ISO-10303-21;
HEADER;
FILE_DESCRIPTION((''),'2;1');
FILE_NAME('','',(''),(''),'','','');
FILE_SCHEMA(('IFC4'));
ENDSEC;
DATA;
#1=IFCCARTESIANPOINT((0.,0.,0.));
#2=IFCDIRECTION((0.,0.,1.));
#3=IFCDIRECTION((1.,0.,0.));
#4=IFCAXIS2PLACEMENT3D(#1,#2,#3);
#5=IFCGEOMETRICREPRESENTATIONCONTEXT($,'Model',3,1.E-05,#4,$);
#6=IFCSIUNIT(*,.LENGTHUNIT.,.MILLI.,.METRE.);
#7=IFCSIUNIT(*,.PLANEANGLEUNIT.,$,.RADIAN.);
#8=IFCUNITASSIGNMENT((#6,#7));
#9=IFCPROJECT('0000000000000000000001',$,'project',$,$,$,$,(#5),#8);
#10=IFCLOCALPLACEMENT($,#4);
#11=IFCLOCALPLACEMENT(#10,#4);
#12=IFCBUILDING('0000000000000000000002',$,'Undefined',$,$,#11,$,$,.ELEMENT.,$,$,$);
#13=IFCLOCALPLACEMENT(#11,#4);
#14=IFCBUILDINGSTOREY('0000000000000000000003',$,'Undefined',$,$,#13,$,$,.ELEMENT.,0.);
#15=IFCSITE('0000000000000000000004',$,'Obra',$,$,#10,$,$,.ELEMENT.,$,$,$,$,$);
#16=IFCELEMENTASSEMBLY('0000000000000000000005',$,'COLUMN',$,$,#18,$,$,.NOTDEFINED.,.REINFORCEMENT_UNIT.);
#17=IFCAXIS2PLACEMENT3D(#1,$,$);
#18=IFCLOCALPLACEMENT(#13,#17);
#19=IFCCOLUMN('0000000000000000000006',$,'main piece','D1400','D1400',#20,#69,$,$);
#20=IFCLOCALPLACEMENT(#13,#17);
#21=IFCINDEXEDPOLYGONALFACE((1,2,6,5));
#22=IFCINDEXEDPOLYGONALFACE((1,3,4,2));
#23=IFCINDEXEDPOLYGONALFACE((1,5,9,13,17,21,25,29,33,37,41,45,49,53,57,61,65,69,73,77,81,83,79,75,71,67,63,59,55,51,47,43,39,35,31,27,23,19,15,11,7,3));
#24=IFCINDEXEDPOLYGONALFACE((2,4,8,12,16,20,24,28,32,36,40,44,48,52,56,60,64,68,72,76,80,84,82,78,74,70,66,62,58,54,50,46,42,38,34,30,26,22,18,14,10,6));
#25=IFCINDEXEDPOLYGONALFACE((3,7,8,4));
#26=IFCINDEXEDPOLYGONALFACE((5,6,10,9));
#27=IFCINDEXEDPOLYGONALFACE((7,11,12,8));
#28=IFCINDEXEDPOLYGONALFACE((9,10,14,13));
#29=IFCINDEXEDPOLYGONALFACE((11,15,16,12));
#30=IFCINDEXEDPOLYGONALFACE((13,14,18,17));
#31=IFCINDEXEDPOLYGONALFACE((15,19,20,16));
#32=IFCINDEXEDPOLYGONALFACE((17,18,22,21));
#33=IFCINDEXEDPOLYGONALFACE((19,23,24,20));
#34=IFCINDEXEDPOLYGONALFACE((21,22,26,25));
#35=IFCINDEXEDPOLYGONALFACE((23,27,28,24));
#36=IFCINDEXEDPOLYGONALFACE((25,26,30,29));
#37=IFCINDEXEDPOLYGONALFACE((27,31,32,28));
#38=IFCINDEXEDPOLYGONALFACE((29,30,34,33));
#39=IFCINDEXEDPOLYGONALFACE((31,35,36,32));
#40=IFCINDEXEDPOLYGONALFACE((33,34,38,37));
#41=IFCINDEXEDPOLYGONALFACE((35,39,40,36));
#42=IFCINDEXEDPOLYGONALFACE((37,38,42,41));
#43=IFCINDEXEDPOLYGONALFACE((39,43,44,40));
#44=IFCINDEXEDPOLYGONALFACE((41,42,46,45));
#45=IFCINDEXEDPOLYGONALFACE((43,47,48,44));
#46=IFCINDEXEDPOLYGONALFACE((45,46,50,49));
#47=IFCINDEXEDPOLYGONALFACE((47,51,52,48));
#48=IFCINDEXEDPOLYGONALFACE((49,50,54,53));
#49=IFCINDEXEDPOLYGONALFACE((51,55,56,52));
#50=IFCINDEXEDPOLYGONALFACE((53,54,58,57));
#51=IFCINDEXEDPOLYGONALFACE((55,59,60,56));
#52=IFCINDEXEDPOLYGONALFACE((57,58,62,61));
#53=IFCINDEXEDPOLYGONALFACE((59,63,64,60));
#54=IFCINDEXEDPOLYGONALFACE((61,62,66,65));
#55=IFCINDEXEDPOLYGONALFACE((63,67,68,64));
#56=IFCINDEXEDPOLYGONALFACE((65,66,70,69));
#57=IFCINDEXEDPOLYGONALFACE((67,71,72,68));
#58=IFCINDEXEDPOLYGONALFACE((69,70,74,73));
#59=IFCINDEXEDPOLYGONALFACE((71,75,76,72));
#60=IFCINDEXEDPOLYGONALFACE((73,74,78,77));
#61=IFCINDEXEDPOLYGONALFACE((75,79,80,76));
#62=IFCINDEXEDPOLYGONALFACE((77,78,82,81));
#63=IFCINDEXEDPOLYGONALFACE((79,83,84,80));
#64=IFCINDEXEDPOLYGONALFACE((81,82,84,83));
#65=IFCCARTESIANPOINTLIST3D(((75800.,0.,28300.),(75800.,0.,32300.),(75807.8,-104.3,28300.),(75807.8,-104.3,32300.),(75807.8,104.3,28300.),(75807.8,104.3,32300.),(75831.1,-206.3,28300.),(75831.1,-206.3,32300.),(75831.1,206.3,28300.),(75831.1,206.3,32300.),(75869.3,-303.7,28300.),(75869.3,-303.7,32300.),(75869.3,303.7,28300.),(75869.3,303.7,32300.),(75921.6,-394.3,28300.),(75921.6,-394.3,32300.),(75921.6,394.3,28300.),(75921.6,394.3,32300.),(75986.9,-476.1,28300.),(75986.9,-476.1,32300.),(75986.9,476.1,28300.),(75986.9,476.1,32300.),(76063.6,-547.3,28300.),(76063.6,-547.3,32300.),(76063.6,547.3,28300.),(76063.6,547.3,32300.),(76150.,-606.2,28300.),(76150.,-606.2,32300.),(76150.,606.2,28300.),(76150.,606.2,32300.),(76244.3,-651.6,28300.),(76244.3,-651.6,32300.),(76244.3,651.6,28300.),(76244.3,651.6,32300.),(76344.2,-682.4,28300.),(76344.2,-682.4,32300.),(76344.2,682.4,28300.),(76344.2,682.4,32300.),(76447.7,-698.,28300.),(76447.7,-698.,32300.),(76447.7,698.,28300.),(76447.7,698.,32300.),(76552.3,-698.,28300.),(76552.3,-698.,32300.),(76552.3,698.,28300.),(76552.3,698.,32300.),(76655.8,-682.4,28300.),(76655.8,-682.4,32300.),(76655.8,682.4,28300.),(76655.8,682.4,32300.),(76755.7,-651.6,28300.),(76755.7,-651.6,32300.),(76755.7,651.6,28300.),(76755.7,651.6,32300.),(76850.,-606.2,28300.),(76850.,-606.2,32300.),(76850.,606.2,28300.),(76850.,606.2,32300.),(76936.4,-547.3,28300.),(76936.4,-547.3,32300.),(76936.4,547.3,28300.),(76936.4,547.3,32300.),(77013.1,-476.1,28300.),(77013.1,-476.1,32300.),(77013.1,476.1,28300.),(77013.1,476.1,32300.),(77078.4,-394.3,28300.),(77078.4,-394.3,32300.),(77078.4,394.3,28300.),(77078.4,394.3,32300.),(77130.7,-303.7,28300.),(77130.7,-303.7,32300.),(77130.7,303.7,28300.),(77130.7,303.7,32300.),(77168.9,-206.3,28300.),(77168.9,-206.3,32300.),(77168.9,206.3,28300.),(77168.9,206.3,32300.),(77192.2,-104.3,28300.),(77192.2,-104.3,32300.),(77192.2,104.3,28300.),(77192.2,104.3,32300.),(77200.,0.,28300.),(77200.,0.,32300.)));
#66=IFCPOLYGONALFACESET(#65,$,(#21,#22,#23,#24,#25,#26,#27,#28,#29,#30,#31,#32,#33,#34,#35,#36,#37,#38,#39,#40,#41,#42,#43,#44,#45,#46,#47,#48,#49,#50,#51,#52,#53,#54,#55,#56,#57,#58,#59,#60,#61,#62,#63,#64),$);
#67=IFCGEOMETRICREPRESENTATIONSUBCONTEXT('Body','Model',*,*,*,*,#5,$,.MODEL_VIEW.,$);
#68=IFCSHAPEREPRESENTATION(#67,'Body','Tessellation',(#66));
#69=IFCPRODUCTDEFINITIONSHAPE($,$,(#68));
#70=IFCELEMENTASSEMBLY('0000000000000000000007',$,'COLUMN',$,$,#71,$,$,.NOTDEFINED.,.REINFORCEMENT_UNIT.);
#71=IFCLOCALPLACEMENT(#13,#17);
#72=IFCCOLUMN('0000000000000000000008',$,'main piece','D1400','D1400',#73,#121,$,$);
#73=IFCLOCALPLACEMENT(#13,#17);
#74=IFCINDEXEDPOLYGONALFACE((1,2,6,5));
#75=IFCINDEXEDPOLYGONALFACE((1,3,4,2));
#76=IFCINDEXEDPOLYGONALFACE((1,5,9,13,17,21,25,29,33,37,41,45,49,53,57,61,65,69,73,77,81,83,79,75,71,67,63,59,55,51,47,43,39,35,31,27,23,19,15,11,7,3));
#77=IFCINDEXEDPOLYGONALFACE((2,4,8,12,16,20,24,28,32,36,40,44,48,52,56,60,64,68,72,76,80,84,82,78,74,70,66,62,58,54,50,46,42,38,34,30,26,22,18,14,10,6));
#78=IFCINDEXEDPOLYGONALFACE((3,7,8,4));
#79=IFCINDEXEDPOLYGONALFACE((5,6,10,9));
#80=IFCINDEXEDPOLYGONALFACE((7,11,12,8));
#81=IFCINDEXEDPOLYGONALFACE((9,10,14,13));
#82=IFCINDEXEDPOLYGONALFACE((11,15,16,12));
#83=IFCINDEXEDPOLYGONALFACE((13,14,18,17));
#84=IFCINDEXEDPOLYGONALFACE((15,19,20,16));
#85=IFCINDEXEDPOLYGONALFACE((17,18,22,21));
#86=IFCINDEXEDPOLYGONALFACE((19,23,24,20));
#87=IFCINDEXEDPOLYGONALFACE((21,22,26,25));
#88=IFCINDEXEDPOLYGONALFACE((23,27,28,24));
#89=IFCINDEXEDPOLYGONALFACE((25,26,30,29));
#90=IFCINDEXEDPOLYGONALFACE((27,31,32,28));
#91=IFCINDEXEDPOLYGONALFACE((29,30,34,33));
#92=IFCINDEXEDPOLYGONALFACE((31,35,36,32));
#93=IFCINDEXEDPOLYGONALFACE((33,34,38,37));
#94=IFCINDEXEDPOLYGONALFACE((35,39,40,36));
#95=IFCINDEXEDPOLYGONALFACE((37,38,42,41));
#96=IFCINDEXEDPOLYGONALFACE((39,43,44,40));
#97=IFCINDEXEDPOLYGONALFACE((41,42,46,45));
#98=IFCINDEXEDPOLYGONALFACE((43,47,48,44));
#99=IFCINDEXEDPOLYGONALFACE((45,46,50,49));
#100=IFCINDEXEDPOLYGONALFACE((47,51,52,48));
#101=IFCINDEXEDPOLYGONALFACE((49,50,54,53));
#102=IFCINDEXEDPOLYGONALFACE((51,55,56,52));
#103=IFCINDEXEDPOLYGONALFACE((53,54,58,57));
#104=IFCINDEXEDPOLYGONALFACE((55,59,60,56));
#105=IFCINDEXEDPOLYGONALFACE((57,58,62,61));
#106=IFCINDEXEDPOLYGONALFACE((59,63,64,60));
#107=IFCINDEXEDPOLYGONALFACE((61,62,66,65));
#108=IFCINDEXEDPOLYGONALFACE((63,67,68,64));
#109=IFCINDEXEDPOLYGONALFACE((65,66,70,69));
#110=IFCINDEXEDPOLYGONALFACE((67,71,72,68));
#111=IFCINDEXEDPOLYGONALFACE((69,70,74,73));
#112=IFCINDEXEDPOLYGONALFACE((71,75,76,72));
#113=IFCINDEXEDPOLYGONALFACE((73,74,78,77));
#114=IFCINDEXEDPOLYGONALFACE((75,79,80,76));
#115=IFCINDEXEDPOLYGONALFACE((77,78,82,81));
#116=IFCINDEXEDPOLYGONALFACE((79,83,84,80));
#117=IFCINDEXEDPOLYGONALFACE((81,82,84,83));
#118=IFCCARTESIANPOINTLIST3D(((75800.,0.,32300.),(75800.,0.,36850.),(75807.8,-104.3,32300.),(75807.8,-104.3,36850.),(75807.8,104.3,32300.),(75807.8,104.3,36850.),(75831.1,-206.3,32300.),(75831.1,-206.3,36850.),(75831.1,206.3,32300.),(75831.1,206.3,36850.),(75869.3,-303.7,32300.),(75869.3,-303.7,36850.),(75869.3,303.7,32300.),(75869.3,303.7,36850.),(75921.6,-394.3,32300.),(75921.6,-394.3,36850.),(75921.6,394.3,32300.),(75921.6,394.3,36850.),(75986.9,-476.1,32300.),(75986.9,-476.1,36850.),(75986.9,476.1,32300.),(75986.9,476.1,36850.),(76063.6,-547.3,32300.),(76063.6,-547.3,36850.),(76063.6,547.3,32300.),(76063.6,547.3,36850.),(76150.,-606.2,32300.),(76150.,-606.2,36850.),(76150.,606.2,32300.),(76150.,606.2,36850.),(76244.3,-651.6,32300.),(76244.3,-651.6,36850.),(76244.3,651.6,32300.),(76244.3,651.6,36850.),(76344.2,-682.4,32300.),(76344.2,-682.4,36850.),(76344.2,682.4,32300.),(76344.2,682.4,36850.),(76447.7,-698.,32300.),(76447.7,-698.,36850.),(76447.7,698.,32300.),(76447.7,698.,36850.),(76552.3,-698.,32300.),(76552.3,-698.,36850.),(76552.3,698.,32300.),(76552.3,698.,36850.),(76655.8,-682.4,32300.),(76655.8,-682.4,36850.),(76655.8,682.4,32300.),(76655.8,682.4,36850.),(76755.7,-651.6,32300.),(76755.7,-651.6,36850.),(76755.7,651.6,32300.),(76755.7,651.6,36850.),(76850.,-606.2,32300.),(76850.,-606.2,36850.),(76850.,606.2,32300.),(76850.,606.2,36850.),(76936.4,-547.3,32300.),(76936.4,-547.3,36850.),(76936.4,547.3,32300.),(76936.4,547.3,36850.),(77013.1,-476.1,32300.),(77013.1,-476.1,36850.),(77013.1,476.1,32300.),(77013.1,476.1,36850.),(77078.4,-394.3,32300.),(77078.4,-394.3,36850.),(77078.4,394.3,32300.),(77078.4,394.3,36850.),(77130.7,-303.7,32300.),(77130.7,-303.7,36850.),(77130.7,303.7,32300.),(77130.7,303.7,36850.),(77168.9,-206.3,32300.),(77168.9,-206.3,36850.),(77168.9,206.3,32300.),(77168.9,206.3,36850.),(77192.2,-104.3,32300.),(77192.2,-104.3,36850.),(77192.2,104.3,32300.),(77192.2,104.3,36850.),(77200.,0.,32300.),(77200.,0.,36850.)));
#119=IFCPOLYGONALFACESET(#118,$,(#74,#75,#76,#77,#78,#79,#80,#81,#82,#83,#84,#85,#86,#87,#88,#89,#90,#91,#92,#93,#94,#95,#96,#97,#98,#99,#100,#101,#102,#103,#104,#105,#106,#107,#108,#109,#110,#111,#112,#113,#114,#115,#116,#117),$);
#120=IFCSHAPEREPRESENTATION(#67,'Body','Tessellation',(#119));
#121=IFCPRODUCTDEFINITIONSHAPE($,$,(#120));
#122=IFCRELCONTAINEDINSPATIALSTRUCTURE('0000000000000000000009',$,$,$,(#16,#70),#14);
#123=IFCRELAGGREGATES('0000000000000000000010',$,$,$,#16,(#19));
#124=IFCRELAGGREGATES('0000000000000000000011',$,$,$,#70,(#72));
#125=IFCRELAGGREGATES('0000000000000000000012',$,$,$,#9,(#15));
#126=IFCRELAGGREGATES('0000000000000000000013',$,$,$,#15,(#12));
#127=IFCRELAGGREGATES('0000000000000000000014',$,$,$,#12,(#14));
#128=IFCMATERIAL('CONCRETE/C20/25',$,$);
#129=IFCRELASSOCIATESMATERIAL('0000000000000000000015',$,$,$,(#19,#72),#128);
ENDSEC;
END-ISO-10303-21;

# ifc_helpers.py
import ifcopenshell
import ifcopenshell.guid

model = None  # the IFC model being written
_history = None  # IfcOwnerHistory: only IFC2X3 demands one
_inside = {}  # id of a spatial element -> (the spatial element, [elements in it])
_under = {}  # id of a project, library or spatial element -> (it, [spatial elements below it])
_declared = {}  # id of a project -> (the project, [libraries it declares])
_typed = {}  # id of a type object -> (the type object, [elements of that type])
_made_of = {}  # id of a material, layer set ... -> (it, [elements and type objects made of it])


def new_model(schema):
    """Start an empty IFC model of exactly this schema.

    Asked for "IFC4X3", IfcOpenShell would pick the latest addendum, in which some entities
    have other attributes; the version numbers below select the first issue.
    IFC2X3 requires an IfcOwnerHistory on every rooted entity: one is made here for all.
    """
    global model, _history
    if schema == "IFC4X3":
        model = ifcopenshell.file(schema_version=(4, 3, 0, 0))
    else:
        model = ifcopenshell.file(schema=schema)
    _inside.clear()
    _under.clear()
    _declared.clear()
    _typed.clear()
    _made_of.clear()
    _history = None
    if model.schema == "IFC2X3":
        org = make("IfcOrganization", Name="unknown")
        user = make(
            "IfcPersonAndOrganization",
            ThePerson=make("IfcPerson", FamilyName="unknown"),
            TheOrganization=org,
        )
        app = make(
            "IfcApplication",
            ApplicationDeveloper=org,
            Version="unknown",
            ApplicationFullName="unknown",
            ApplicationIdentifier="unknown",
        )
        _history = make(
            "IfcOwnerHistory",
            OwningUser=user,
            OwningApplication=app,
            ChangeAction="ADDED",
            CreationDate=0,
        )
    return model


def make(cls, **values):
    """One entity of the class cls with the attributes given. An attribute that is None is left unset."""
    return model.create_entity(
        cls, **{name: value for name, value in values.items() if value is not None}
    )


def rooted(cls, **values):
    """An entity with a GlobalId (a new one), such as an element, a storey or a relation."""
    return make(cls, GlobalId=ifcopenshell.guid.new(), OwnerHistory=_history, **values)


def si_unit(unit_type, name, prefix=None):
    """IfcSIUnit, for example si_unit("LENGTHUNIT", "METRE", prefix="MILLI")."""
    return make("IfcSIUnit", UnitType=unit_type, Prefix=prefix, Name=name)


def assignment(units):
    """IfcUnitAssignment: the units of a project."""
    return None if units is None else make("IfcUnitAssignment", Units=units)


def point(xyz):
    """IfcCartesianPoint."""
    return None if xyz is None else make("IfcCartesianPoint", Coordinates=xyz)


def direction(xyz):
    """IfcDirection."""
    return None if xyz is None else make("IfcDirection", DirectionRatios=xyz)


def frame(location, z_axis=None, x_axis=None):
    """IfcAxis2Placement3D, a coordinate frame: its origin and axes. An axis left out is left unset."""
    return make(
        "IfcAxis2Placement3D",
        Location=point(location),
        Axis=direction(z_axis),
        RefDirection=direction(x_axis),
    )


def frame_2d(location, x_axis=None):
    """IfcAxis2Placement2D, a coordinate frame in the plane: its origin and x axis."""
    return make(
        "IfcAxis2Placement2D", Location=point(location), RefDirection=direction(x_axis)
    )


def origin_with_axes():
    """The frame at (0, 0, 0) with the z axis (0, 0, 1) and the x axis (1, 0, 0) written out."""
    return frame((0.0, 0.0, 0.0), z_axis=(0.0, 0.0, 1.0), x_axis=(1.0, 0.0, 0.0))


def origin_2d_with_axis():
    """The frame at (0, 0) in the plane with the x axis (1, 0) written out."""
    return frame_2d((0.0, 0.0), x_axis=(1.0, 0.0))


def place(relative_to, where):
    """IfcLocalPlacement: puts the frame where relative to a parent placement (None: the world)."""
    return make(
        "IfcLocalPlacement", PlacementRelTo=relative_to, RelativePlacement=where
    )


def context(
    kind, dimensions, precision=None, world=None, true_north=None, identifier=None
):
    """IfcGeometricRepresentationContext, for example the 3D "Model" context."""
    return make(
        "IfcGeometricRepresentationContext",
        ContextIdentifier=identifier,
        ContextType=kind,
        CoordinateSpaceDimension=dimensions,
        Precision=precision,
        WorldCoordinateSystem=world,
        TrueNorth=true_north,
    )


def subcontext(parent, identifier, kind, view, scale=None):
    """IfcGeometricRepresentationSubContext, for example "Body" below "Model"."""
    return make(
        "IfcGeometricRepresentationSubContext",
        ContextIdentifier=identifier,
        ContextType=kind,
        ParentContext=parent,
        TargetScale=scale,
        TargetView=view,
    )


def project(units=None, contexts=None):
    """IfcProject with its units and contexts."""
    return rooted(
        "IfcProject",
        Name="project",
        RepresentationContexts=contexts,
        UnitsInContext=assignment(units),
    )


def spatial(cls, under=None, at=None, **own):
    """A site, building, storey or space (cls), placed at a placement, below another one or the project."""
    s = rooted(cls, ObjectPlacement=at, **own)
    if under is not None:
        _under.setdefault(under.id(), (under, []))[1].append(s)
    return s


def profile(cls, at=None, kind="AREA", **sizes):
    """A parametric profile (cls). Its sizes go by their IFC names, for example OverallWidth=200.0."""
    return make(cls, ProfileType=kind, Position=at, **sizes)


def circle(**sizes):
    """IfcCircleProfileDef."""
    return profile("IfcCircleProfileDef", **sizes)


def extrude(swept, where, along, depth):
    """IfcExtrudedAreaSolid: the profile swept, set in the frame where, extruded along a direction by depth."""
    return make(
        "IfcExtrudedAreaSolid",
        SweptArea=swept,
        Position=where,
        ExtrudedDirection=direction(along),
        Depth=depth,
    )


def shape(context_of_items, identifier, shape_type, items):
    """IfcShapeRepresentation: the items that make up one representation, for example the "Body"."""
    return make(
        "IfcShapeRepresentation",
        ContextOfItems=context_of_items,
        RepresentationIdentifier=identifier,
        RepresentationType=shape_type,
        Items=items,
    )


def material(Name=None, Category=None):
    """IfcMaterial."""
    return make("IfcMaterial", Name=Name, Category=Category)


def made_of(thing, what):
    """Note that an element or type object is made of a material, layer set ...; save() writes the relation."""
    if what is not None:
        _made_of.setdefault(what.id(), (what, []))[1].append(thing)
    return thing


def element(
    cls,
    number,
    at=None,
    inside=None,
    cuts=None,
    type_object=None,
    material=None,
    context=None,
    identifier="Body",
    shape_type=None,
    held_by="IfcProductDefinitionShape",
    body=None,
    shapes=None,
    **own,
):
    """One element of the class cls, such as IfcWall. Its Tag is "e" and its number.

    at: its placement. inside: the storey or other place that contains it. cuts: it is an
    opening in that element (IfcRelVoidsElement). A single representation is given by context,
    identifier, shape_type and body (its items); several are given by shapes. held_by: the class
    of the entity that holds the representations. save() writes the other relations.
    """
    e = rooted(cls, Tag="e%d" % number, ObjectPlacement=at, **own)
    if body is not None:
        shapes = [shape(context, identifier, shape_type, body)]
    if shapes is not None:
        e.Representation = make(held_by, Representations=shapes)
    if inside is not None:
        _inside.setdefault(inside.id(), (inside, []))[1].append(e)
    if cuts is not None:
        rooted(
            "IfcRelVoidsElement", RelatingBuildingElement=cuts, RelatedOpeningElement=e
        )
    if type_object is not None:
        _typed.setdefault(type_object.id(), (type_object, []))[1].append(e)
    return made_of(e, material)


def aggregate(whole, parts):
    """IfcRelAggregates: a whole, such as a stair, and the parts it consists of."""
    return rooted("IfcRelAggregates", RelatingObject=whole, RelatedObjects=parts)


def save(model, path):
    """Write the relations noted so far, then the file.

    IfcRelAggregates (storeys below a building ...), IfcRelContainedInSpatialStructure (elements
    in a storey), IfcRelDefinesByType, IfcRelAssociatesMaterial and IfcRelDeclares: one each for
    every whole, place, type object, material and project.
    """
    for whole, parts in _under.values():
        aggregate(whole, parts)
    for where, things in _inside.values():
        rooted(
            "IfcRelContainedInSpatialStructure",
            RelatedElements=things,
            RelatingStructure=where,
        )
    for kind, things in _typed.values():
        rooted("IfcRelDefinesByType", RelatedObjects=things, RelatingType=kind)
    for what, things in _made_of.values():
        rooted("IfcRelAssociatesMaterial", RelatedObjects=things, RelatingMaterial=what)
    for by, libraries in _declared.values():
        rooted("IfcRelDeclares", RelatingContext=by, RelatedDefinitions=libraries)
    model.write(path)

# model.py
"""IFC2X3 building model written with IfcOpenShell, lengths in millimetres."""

from ifc_helpers import new_model, si_unit, frame, origin_with_axes, origin_2d_with_axis, place, context, subcontext, project, spatial, circle, extrude, material, element, aggregate, save


model = new_model("IFC2X3")

# Units and contexts
model_context = context("Model", 3, precision=1e-05, world=origin_with_axes())
body_context = subcontext(model_context, "Body", "Model", "MODEL_VIEW")
ifc_project = project(units=[si_unit("LENGTHUNIT", "METRE", prefix="MILLI"), si_unit("PLANEANGLEUNIT", "RADIAN")], contexts=[model_context])

# Site, building, storey
site_placement = place(None, origin_with_axes())
site = spatial("IfcSite", under=ifc_project, at=site_placement, Name="Obra", CompositionType="ELEMENT")
building_placement = place(site_placement, origin_with_axes())
building = spatial("IfcBuilding", under=site, at=building_placement, Name="Undefined", CompositionType="ELEMENT")
storey_placement = place(building_placement, origin_with_axes())
storey = spatial("IfcBuildingStorey", under=building, at=storey_placement, Name="Undefined", CompositionType="ELEMENT", Elevation=0.0)

# Element assemblies, columns
assembly_1_placement = place(storey_placement, origin_with_axes())
assembly_1 = element("IfcElementAssembly", 1, at=assembly_1_placement, inside=storey, Name="COLUMN", AssemblyPlace="NOTDEFINED", PredefinedType="REINFORCEMENT_UNIT")
ifc_material_1 = material(Name="CONCRETE/C20/25")
column_1_placement = place(assembly_1_placement, frame((76500.0, 0.0, 28300.0), z_axis=(0.0, 0.0, 1.0), x_axis=(0.0, 1.0, 0.0)))
column_1 = element("IfcColumn", 2, at=column_1_placement, material=ifc_material_1, Name="main piece", Description="D1400", ObjectType="D1400", context=body_context, shape_type="SweptSolid", body=[
    extrude(circle(Radius=700.0, at=origin_2d_with_axis()), frame((0.0, 0.0, 4000.0), z_axis=(0.0, 0.0, -1.0), x_axis=(0.0, 1.0, 0.0)), (0.0, 0.0, 1.0), 4000.0),
])
aggregate(assembly_1, [column_1])
assembly_2_placement = place(storey_placement, origin_with_axes())
assembly_2 = element("IfcElementAssembly", 3, at=assembly_2_placement, inside=storey, Name="COLUMN", AssemblyPlace="NOTDEFINED", PredefinedType="REINFORCEMENT_UNIT")
column_2_placement = place(assembly_2_placement, frame((76500.0, 0.0, 32300.0), z_axis=(0.0, 0.0, 1.0), x_axis=(0.0, 1.0, 0.0)))
column_2 = element("IfcColumn", 4, at=column_2_placement, material=ifc_material_1, Name="main piece", Description="D1400", ObjectType="D1400", context=body_context, shape_type="SweptSolid", body=[
    extrude(circle(Radius=700.0, at=origin_2d_with_axis()), frame((0.0, 0.0, 4550.0), z_axis=(0.0, 0.0, -1.0), x_axis=(0.0, 1.0, 0.0)), (0.0, 0.0, 1.0), 4550.0),
])
aggregate(assembly_2, [column_2])

save(model, "model.ifc")
